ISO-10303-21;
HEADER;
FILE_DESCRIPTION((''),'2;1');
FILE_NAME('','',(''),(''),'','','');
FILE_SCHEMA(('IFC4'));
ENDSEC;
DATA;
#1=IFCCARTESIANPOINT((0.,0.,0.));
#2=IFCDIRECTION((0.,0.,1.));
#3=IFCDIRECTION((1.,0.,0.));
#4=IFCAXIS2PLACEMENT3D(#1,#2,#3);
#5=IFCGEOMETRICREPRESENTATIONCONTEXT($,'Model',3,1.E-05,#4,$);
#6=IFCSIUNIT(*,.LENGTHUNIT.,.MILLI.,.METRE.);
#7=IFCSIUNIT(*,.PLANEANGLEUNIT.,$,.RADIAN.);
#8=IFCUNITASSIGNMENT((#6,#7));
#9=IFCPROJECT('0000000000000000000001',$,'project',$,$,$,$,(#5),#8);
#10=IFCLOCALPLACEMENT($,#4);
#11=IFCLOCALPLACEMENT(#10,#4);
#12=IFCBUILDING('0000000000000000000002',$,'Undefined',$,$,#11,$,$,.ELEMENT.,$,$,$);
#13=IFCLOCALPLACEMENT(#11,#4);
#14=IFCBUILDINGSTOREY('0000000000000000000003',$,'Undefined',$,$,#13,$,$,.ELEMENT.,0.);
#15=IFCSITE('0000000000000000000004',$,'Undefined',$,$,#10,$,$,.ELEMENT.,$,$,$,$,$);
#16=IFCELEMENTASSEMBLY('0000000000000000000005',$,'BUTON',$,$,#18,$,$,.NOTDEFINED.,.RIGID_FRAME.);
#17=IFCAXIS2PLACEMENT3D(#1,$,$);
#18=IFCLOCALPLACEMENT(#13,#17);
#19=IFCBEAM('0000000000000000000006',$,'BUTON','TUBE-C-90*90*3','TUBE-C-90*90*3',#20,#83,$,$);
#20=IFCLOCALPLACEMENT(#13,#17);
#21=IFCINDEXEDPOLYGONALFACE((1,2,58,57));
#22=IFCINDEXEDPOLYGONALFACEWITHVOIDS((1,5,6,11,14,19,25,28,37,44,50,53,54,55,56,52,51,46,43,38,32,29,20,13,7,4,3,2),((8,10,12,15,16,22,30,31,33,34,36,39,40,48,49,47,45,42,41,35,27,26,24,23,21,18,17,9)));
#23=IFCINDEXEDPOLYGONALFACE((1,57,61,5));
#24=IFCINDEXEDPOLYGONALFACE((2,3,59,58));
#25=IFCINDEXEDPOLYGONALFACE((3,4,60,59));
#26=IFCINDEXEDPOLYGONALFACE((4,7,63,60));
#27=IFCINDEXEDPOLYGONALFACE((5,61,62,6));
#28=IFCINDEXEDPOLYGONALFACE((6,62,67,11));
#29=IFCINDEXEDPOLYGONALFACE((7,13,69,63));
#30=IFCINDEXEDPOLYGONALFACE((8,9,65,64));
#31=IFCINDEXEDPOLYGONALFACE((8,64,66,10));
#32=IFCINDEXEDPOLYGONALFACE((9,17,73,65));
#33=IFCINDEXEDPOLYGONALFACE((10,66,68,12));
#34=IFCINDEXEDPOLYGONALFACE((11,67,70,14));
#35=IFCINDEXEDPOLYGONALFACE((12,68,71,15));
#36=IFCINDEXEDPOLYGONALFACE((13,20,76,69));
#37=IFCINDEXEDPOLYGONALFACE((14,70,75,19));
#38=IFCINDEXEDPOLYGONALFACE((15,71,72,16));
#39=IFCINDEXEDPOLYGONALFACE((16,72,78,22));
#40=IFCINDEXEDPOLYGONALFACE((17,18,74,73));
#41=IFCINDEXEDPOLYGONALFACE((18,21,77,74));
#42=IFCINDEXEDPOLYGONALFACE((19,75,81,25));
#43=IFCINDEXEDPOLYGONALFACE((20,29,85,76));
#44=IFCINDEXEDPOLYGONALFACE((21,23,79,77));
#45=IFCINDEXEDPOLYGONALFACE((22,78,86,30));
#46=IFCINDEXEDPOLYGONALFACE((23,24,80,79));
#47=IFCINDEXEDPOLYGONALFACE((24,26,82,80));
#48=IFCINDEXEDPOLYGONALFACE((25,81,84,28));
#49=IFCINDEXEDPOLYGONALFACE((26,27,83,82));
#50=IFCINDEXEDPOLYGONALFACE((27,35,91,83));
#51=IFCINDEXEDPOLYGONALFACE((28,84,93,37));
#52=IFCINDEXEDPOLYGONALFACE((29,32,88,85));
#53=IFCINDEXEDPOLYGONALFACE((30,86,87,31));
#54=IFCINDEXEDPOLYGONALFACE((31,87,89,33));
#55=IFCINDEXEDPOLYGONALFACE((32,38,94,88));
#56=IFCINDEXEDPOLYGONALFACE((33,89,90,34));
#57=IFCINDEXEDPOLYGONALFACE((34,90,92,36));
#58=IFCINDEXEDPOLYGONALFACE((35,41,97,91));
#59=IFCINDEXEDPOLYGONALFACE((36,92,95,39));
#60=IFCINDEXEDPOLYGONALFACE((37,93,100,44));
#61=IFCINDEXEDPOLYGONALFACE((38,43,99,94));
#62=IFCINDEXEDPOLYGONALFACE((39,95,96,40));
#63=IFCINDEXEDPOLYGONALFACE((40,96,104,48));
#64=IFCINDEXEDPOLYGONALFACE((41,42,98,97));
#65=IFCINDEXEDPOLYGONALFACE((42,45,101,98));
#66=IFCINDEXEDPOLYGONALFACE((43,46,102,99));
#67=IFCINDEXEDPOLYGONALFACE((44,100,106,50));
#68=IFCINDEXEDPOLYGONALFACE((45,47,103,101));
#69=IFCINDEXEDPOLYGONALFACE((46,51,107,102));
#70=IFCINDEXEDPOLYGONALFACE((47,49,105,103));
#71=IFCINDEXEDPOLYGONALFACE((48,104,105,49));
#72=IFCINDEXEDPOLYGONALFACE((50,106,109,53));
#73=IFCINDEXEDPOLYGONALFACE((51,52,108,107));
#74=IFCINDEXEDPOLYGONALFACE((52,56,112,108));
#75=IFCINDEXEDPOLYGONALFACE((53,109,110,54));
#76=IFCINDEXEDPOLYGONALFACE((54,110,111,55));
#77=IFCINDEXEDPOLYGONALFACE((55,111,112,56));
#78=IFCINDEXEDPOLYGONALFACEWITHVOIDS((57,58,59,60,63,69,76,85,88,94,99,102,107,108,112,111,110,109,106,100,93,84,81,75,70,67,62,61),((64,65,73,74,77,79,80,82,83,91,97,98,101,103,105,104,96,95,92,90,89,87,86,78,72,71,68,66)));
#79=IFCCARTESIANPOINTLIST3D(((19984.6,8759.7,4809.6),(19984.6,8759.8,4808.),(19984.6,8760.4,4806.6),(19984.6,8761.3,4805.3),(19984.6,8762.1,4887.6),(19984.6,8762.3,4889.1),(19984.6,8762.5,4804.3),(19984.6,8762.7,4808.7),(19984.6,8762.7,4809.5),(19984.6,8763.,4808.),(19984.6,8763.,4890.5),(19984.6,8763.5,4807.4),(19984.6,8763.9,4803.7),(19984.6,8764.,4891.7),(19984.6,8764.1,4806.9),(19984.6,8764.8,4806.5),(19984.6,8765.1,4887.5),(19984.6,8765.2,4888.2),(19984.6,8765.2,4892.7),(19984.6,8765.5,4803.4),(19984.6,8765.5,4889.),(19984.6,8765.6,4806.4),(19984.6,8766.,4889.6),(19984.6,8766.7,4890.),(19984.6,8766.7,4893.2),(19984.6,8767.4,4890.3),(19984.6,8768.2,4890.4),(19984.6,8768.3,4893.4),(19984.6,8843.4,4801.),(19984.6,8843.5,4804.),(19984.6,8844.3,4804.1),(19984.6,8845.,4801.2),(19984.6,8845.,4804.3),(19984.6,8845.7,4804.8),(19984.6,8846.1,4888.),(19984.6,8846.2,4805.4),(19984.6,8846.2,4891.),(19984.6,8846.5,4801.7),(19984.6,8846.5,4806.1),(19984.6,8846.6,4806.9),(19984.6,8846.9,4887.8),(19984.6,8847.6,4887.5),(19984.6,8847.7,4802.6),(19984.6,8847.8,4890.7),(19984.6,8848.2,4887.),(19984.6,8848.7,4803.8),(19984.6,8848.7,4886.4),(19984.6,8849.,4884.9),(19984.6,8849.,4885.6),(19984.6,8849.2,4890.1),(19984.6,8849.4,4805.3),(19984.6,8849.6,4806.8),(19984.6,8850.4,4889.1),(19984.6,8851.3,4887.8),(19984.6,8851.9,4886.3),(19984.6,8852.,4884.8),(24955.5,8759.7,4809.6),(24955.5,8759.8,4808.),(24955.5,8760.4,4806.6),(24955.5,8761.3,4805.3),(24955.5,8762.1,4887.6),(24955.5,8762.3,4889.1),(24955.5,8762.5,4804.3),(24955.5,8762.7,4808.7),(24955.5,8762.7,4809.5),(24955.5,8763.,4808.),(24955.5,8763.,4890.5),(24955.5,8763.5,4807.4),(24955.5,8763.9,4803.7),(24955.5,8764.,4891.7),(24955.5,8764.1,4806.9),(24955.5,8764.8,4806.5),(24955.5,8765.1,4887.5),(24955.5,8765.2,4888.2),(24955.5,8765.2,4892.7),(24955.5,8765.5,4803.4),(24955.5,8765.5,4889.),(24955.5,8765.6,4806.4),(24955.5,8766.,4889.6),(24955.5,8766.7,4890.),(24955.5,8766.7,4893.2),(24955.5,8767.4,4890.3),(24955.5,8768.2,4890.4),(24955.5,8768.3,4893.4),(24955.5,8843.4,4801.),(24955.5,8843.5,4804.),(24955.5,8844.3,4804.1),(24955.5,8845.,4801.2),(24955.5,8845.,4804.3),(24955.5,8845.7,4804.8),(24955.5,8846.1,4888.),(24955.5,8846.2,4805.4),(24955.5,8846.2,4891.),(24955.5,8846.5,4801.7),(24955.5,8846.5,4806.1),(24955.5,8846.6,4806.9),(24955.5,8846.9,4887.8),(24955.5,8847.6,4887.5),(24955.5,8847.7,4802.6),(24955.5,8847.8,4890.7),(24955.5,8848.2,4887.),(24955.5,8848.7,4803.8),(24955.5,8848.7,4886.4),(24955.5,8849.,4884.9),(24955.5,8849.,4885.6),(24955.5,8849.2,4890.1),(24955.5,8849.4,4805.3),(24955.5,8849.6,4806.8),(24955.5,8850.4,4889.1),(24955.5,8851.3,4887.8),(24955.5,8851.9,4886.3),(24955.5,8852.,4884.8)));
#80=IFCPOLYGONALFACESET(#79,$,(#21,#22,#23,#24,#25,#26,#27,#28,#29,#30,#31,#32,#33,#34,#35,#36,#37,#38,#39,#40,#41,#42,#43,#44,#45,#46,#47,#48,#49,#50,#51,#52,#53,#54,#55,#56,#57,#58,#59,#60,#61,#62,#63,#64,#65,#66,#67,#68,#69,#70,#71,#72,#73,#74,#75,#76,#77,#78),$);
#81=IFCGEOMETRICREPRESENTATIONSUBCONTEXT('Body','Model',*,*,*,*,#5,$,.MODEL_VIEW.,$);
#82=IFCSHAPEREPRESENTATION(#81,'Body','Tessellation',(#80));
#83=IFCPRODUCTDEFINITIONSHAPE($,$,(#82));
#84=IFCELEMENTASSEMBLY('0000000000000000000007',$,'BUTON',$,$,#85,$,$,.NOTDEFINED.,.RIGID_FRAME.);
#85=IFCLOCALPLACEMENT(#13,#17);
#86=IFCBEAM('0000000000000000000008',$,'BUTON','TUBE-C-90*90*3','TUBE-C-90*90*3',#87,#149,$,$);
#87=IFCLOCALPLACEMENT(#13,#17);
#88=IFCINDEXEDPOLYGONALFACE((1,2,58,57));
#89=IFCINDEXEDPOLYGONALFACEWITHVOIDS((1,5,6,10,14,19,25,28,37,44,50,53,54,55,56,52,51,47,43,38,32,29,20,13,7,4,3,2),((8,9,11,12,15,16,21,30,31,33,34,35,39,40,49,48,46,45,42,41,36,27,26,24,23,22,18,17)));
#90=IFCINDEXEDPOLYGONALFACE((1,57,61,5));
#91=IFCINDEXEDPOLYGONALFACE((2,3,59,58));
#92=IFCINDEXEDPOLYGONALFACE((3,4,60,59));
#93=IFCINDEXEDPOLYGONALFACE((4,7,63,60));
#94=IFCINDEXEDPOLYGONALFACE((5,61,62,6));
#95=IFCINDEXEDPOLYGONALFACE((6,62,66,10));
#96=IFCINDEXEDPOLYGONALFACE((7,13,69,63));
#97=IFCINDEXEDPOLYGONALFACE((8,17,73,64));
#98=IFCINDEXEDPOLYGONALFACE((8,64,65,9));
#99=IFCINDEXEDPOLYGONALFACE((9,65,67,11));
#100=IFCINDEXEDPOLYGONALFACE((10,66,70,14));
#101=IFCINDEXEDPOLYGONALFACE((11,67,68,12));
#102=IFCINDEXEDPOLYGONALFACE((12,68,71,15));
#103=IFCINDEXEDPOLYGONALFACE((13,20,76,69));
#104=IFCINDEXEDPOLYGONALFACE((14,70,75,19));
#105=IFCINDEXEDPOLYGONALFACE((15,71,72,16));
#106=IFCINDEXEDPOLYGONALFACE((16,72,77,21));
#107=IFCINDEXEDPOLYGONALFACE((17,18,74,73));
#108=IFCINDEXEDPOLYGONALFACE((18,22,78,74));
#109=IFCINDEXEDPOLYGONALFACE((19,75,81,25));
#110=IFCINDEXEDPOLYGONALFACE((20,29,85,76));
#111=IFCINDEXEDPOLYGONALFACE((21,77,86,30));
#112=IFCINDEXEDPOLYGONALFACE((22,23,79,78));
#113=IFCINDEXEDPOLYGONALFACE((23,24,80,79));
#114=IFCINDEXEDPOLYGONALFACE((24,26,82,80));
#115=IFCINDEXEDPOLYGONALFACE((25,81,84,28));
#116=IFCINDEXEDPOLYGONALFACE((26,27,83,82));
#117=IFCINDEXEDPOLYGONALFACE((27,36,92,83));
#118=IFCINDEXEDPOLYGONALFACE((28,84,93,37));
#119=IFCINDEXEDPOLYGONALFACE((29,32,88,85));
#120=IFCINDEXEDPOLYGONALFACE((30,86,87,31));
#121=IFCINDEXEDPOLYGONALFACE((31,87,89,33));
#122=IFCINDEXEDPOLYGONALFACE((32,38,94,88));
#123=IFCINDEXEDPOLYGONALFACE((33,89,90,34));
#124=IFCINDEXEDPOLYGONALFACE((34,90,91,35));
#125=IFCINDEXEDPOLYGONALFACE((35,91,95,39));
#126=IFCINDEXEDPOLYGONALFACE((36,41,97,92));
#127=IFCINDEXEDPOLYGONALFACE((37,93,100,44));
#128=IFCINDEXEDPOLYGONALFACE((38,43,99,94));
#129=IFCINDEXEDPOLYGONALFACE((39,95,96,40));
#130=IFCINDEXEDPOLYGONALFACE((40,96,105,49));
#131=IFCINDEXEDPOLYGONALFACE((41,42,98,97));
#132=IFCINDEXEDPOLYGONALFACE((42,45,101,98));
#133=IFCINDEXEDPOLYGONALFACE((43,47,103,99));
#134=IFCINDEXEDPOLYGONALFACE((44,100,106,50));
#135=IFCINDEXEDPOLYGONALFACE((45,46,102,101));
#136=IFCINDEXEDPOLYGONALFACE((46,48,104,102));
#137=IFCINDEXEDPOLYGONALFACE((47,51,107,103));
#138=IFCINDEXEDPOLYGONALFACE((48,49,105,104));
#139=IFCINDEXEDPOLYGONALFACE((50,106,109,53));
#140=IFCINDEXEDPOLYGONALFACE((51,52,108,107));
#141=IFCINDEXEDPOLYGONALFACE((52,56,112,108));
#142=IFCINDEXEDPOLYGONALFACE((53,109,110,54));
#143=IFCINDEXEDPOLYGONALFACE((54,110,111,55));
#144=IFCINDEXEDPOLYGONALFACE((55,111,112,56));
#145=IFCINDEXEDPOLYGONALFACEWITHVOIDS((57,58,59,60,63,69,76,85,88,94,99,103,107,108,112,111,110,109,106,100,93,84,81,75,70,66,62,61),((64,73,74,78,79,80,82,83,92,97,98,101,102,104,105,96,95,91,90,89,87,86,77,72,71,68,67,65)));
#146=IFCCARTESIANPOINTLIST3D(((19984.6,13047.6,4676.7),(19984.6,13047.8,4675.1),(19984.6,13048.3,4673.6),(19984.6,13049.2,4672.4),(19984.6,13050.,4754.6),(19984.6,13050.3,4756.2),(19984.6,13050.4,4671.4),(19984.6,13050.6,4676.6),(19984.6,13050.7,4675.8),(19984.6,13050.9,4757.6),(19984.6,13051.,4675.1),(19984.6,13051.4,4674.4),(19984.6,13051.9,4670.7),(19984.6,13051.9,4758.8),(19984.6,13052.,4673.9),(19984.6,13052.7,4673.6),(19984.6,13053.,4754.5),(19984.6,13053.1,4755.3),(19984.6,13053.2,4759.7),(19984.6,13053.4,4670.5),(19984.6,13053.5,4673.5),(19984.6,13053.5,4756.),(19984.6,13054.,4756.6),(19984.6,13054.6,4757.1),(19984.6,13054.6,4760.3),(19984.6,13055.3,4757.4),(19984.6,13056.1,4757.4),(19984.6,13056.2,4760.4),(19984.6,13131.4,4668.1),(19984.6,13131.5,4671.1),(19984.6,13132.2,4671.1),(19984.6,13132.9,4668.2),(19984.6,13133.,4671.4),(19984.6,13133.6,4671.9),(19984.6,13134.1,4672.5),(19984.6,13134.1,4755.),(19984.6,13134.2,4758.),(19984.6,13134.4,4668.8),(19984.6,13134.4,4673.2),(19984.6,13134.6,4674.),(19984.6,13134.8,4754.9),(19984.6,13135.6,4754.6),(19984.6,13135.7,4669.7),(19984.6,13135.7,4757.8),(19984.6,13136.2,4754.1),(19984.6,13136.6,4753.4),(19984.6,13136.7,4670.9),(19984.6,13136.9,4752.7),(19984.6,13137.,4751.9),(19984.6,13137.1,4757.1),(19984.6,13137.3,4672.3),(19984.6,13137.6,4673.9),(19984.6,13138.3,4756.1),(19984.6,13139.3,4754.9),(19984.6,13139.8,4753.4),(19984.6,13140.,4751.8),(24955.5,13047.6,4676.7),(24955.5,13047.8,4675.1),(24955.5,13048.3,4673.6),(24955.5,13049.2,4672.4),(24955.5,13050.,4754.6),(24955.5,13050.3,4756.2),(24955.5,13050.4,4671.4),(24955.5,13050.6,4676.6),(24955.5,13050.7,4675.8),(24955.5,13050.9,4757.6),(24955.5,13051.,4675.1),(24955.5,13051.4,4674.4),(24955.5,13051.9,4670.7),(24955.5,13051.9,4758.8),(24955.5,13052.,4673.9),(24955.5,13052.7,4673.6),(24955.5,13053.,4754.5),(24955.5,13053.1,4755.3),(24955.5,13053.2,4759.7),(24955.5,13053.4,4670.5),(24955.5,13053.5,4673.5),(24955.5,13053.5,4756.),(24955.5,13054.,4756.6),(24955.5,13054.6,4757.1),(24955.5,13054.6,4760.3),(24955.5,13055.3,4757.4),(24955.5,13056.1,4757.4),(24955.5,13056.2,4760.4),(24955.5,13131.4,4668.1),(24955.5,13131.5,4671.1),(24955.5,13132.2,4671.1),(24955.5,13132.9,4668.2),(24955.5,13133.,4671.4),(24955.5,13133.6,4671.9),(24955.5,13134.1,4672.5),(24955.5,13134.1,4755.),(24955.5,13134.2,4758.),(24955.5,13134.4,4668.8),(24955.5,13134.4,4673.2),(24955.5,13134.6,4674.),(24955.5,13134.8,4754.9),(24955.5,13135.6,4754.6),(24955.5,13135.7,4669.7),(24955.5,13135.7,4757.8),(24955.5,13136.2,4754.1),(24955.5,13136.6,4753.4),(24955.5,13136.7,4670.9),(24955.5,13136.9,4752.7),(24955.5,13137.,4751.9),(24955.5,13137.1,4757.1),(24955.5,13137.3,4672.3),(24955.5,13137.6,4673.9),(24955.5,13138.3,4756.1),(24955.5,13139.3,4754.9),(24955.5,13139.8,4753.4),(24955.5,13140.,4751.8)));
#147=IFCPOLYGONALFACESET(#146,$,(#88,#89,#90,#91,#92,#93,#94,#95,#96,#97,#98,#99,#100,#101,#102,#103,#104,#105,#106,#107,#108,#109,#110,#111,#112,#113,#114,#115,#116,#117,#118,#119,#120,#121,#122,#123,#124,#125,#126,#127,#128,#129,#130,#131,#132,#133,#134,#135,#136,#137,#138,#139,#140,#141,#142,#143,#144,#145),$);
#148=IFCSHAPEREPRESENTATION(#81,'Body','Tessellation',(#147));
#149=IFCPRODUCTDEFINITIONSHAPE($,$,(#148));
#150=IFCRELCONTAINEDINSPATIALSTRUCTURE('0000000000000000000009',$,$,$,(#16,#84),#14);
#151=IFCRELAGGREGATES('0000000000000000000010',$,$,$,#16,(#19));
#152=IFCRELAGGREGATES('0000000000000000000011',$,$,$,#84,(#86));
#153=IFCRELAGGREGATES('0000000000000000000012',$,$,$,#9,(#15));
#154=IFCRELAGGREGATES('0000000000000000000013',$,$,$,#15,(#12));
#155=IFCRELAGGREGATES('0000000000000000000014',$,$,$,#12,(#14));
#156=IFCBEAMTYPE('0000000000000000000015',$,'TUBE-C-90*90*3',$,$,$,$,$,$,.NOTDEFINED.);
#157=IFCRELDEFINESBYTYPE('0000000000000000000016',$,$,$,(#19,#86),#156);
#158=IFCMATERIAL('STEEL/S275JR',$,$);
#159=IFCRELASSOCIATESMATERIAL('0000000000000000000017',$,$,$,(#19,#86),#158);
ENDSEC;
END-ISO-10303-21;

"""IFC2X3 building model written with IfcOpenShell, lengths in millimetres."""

from ifc_helpers import new_model, si_unit, frame, origin_with_axes, origin_2d_with_axis, place, context, subcontext, project, spatial, hollow_rectangle, extrude, clip, halfspace, material, type_object, element, aggregate, save


model = new_model("IFC2X3")

# Units and contexts
model_context = context("Model", 3, precision=1e-05, world=origin_with_axes())
body_context = subcontext(model_context, "Body", "Model", "MODEL_VIEW")
ifc_project = project(units=[si_unit("LENGTHUNIT", "METRE", prefix="MILLI"), si_unit("PLANEANGLEUNIT", "RADIAN")], contexts=[model_context])

# Site, building, storey
site_placement = place(None, origin_with_axes())
site = spatial("IfcSite", under=ifc_project, at=site_placement, Name="Undefined", CompositionType="ELEMENT")
building_placement = place(site_placement, origin_with_axes())
building = spatial("IfcBuilding", under=site, at=building_placement, Name="Undefined", CompositionType="ELEMENT")
storey_placement = place(building_placement, origin_with_axes())
storey = spatial("IfcBuildingStorey", under=building, at=storey_placement, Name="Undefined", CompositionType="ELEMENT", Elevation=0.0)

# Element assemblies, beams
assembly_1_placement = place(storey_placement, origin_with_axes())
assembly_1 = element("IfcElementAssembly", 1, at=assembly_1_placement, inside=storey, Name="BUTON", AssemblyPlace="NOTDEFINED", PredefinedType="RIGID_FRAME")
ifc_material_1 = material(Name="STEEL/S275JR")
beam_type_1 = type_object("IfcBeamType", Name="TUBE-C-90*90*3", PredefinedType="NOTDEFINED")
beam_1_placement = place(assembly_1_placement, frame((19970.0, 8805.8, 4847.2), z_axis=(0.0, -0.99952, 0.030986), x_axis=(1.0, 0.0, 0.0)))
beam_1 = element("IfcBeam", 2, at=beam_1_placement, type_object=beam_type_1, material=ifc_material_1, Name="BUTON", Description="TUBE-C-90*90*3", ObjectType="TUBE-C-90*90*3", context=body_context, shape_type="Clipping", body=[
    clip(clip(extrude(hollow_rectangle(XDim=90.0, YDim=90.0, WallThickness=3.0, InnerFilletRadius=3.0, OuterFilletRadius=6.0, at=origin_2d_with_axis()), frame((4985.5, 0.0, 0.0), z_axis=(-1.0, 0.0, 0.0), x_axis=(0.0, -1.0, 0.0)), (0.0, 0.0, 1.0), 4970.9), halfspace(frame((4985.5, 0.0, -45.0), z_axis=(-1.0, 0.0, 0.0), x_axis=(0.0, 1.0, 0.0)), True)), halfspace(frame((14.5, 0.0, -45.0), z_axis=(1.0, 0.0, 0.0), x_axis=(0.0, -1.0, 0.0)), True)),
])
assembly_2_placement = place(storey_placement, origin_with_axes())
assembly_2 = element("IfcElementAssembly", 3, at=assembly_2_placement, inside=storey, Name="BUTON", AssemblyPlace="NOTDEFINED", PredefinedType="RIGID_FRAME")
beam_2_placement = place(assembly_2_placement, frame((19970.0, 13093.8, 4714.3), z_axis=(0.0, -0.99952, 0.030986), x_axis=(1.0, 0.0, 0.0)))
beam_2 = element("IfcBeam", 4, at=beam_2_placement, type_object=beam_type_1, material=ifc_material_1, Name="BUTON", Description="TUBE-C-90*90*3", ObjectType="TUBE-C-90*90*3", context=body_context, shape_type="Clipping", body=[
    clip(clip(extrude(hollow_rectangle(XDim=90.0, YDim=90.0, WallThickness=3.0, InnerFilletRadius=3.0, OuterFilletRadius=6.0, at=origin_2d_with_axis()), frame((4985.5, 0.0, 0.0), z_axis=(-1.0, 0.0, 0.0), x_axis=(0.0, -1.0, 0.0)), (0.0, 0.0, 1.0), 4970.9), halfspace(frame((4985.5, 0.0, -45.0), z_axis=(-1.0, 0.0, 0.0), x_axis=(0.0, 1.0, 0.0)), True)), halfspace(frame((14.5, 0.0, -45.0), z_axis=(1.0, 0.0, 0.0), x_axis=(0.0, -1.0, 0.0)), True)),
])

aggregate(assembly_1, [beam_1])
aggregate(assembly_2, [beam_2])

save(model, "model.ifc")
